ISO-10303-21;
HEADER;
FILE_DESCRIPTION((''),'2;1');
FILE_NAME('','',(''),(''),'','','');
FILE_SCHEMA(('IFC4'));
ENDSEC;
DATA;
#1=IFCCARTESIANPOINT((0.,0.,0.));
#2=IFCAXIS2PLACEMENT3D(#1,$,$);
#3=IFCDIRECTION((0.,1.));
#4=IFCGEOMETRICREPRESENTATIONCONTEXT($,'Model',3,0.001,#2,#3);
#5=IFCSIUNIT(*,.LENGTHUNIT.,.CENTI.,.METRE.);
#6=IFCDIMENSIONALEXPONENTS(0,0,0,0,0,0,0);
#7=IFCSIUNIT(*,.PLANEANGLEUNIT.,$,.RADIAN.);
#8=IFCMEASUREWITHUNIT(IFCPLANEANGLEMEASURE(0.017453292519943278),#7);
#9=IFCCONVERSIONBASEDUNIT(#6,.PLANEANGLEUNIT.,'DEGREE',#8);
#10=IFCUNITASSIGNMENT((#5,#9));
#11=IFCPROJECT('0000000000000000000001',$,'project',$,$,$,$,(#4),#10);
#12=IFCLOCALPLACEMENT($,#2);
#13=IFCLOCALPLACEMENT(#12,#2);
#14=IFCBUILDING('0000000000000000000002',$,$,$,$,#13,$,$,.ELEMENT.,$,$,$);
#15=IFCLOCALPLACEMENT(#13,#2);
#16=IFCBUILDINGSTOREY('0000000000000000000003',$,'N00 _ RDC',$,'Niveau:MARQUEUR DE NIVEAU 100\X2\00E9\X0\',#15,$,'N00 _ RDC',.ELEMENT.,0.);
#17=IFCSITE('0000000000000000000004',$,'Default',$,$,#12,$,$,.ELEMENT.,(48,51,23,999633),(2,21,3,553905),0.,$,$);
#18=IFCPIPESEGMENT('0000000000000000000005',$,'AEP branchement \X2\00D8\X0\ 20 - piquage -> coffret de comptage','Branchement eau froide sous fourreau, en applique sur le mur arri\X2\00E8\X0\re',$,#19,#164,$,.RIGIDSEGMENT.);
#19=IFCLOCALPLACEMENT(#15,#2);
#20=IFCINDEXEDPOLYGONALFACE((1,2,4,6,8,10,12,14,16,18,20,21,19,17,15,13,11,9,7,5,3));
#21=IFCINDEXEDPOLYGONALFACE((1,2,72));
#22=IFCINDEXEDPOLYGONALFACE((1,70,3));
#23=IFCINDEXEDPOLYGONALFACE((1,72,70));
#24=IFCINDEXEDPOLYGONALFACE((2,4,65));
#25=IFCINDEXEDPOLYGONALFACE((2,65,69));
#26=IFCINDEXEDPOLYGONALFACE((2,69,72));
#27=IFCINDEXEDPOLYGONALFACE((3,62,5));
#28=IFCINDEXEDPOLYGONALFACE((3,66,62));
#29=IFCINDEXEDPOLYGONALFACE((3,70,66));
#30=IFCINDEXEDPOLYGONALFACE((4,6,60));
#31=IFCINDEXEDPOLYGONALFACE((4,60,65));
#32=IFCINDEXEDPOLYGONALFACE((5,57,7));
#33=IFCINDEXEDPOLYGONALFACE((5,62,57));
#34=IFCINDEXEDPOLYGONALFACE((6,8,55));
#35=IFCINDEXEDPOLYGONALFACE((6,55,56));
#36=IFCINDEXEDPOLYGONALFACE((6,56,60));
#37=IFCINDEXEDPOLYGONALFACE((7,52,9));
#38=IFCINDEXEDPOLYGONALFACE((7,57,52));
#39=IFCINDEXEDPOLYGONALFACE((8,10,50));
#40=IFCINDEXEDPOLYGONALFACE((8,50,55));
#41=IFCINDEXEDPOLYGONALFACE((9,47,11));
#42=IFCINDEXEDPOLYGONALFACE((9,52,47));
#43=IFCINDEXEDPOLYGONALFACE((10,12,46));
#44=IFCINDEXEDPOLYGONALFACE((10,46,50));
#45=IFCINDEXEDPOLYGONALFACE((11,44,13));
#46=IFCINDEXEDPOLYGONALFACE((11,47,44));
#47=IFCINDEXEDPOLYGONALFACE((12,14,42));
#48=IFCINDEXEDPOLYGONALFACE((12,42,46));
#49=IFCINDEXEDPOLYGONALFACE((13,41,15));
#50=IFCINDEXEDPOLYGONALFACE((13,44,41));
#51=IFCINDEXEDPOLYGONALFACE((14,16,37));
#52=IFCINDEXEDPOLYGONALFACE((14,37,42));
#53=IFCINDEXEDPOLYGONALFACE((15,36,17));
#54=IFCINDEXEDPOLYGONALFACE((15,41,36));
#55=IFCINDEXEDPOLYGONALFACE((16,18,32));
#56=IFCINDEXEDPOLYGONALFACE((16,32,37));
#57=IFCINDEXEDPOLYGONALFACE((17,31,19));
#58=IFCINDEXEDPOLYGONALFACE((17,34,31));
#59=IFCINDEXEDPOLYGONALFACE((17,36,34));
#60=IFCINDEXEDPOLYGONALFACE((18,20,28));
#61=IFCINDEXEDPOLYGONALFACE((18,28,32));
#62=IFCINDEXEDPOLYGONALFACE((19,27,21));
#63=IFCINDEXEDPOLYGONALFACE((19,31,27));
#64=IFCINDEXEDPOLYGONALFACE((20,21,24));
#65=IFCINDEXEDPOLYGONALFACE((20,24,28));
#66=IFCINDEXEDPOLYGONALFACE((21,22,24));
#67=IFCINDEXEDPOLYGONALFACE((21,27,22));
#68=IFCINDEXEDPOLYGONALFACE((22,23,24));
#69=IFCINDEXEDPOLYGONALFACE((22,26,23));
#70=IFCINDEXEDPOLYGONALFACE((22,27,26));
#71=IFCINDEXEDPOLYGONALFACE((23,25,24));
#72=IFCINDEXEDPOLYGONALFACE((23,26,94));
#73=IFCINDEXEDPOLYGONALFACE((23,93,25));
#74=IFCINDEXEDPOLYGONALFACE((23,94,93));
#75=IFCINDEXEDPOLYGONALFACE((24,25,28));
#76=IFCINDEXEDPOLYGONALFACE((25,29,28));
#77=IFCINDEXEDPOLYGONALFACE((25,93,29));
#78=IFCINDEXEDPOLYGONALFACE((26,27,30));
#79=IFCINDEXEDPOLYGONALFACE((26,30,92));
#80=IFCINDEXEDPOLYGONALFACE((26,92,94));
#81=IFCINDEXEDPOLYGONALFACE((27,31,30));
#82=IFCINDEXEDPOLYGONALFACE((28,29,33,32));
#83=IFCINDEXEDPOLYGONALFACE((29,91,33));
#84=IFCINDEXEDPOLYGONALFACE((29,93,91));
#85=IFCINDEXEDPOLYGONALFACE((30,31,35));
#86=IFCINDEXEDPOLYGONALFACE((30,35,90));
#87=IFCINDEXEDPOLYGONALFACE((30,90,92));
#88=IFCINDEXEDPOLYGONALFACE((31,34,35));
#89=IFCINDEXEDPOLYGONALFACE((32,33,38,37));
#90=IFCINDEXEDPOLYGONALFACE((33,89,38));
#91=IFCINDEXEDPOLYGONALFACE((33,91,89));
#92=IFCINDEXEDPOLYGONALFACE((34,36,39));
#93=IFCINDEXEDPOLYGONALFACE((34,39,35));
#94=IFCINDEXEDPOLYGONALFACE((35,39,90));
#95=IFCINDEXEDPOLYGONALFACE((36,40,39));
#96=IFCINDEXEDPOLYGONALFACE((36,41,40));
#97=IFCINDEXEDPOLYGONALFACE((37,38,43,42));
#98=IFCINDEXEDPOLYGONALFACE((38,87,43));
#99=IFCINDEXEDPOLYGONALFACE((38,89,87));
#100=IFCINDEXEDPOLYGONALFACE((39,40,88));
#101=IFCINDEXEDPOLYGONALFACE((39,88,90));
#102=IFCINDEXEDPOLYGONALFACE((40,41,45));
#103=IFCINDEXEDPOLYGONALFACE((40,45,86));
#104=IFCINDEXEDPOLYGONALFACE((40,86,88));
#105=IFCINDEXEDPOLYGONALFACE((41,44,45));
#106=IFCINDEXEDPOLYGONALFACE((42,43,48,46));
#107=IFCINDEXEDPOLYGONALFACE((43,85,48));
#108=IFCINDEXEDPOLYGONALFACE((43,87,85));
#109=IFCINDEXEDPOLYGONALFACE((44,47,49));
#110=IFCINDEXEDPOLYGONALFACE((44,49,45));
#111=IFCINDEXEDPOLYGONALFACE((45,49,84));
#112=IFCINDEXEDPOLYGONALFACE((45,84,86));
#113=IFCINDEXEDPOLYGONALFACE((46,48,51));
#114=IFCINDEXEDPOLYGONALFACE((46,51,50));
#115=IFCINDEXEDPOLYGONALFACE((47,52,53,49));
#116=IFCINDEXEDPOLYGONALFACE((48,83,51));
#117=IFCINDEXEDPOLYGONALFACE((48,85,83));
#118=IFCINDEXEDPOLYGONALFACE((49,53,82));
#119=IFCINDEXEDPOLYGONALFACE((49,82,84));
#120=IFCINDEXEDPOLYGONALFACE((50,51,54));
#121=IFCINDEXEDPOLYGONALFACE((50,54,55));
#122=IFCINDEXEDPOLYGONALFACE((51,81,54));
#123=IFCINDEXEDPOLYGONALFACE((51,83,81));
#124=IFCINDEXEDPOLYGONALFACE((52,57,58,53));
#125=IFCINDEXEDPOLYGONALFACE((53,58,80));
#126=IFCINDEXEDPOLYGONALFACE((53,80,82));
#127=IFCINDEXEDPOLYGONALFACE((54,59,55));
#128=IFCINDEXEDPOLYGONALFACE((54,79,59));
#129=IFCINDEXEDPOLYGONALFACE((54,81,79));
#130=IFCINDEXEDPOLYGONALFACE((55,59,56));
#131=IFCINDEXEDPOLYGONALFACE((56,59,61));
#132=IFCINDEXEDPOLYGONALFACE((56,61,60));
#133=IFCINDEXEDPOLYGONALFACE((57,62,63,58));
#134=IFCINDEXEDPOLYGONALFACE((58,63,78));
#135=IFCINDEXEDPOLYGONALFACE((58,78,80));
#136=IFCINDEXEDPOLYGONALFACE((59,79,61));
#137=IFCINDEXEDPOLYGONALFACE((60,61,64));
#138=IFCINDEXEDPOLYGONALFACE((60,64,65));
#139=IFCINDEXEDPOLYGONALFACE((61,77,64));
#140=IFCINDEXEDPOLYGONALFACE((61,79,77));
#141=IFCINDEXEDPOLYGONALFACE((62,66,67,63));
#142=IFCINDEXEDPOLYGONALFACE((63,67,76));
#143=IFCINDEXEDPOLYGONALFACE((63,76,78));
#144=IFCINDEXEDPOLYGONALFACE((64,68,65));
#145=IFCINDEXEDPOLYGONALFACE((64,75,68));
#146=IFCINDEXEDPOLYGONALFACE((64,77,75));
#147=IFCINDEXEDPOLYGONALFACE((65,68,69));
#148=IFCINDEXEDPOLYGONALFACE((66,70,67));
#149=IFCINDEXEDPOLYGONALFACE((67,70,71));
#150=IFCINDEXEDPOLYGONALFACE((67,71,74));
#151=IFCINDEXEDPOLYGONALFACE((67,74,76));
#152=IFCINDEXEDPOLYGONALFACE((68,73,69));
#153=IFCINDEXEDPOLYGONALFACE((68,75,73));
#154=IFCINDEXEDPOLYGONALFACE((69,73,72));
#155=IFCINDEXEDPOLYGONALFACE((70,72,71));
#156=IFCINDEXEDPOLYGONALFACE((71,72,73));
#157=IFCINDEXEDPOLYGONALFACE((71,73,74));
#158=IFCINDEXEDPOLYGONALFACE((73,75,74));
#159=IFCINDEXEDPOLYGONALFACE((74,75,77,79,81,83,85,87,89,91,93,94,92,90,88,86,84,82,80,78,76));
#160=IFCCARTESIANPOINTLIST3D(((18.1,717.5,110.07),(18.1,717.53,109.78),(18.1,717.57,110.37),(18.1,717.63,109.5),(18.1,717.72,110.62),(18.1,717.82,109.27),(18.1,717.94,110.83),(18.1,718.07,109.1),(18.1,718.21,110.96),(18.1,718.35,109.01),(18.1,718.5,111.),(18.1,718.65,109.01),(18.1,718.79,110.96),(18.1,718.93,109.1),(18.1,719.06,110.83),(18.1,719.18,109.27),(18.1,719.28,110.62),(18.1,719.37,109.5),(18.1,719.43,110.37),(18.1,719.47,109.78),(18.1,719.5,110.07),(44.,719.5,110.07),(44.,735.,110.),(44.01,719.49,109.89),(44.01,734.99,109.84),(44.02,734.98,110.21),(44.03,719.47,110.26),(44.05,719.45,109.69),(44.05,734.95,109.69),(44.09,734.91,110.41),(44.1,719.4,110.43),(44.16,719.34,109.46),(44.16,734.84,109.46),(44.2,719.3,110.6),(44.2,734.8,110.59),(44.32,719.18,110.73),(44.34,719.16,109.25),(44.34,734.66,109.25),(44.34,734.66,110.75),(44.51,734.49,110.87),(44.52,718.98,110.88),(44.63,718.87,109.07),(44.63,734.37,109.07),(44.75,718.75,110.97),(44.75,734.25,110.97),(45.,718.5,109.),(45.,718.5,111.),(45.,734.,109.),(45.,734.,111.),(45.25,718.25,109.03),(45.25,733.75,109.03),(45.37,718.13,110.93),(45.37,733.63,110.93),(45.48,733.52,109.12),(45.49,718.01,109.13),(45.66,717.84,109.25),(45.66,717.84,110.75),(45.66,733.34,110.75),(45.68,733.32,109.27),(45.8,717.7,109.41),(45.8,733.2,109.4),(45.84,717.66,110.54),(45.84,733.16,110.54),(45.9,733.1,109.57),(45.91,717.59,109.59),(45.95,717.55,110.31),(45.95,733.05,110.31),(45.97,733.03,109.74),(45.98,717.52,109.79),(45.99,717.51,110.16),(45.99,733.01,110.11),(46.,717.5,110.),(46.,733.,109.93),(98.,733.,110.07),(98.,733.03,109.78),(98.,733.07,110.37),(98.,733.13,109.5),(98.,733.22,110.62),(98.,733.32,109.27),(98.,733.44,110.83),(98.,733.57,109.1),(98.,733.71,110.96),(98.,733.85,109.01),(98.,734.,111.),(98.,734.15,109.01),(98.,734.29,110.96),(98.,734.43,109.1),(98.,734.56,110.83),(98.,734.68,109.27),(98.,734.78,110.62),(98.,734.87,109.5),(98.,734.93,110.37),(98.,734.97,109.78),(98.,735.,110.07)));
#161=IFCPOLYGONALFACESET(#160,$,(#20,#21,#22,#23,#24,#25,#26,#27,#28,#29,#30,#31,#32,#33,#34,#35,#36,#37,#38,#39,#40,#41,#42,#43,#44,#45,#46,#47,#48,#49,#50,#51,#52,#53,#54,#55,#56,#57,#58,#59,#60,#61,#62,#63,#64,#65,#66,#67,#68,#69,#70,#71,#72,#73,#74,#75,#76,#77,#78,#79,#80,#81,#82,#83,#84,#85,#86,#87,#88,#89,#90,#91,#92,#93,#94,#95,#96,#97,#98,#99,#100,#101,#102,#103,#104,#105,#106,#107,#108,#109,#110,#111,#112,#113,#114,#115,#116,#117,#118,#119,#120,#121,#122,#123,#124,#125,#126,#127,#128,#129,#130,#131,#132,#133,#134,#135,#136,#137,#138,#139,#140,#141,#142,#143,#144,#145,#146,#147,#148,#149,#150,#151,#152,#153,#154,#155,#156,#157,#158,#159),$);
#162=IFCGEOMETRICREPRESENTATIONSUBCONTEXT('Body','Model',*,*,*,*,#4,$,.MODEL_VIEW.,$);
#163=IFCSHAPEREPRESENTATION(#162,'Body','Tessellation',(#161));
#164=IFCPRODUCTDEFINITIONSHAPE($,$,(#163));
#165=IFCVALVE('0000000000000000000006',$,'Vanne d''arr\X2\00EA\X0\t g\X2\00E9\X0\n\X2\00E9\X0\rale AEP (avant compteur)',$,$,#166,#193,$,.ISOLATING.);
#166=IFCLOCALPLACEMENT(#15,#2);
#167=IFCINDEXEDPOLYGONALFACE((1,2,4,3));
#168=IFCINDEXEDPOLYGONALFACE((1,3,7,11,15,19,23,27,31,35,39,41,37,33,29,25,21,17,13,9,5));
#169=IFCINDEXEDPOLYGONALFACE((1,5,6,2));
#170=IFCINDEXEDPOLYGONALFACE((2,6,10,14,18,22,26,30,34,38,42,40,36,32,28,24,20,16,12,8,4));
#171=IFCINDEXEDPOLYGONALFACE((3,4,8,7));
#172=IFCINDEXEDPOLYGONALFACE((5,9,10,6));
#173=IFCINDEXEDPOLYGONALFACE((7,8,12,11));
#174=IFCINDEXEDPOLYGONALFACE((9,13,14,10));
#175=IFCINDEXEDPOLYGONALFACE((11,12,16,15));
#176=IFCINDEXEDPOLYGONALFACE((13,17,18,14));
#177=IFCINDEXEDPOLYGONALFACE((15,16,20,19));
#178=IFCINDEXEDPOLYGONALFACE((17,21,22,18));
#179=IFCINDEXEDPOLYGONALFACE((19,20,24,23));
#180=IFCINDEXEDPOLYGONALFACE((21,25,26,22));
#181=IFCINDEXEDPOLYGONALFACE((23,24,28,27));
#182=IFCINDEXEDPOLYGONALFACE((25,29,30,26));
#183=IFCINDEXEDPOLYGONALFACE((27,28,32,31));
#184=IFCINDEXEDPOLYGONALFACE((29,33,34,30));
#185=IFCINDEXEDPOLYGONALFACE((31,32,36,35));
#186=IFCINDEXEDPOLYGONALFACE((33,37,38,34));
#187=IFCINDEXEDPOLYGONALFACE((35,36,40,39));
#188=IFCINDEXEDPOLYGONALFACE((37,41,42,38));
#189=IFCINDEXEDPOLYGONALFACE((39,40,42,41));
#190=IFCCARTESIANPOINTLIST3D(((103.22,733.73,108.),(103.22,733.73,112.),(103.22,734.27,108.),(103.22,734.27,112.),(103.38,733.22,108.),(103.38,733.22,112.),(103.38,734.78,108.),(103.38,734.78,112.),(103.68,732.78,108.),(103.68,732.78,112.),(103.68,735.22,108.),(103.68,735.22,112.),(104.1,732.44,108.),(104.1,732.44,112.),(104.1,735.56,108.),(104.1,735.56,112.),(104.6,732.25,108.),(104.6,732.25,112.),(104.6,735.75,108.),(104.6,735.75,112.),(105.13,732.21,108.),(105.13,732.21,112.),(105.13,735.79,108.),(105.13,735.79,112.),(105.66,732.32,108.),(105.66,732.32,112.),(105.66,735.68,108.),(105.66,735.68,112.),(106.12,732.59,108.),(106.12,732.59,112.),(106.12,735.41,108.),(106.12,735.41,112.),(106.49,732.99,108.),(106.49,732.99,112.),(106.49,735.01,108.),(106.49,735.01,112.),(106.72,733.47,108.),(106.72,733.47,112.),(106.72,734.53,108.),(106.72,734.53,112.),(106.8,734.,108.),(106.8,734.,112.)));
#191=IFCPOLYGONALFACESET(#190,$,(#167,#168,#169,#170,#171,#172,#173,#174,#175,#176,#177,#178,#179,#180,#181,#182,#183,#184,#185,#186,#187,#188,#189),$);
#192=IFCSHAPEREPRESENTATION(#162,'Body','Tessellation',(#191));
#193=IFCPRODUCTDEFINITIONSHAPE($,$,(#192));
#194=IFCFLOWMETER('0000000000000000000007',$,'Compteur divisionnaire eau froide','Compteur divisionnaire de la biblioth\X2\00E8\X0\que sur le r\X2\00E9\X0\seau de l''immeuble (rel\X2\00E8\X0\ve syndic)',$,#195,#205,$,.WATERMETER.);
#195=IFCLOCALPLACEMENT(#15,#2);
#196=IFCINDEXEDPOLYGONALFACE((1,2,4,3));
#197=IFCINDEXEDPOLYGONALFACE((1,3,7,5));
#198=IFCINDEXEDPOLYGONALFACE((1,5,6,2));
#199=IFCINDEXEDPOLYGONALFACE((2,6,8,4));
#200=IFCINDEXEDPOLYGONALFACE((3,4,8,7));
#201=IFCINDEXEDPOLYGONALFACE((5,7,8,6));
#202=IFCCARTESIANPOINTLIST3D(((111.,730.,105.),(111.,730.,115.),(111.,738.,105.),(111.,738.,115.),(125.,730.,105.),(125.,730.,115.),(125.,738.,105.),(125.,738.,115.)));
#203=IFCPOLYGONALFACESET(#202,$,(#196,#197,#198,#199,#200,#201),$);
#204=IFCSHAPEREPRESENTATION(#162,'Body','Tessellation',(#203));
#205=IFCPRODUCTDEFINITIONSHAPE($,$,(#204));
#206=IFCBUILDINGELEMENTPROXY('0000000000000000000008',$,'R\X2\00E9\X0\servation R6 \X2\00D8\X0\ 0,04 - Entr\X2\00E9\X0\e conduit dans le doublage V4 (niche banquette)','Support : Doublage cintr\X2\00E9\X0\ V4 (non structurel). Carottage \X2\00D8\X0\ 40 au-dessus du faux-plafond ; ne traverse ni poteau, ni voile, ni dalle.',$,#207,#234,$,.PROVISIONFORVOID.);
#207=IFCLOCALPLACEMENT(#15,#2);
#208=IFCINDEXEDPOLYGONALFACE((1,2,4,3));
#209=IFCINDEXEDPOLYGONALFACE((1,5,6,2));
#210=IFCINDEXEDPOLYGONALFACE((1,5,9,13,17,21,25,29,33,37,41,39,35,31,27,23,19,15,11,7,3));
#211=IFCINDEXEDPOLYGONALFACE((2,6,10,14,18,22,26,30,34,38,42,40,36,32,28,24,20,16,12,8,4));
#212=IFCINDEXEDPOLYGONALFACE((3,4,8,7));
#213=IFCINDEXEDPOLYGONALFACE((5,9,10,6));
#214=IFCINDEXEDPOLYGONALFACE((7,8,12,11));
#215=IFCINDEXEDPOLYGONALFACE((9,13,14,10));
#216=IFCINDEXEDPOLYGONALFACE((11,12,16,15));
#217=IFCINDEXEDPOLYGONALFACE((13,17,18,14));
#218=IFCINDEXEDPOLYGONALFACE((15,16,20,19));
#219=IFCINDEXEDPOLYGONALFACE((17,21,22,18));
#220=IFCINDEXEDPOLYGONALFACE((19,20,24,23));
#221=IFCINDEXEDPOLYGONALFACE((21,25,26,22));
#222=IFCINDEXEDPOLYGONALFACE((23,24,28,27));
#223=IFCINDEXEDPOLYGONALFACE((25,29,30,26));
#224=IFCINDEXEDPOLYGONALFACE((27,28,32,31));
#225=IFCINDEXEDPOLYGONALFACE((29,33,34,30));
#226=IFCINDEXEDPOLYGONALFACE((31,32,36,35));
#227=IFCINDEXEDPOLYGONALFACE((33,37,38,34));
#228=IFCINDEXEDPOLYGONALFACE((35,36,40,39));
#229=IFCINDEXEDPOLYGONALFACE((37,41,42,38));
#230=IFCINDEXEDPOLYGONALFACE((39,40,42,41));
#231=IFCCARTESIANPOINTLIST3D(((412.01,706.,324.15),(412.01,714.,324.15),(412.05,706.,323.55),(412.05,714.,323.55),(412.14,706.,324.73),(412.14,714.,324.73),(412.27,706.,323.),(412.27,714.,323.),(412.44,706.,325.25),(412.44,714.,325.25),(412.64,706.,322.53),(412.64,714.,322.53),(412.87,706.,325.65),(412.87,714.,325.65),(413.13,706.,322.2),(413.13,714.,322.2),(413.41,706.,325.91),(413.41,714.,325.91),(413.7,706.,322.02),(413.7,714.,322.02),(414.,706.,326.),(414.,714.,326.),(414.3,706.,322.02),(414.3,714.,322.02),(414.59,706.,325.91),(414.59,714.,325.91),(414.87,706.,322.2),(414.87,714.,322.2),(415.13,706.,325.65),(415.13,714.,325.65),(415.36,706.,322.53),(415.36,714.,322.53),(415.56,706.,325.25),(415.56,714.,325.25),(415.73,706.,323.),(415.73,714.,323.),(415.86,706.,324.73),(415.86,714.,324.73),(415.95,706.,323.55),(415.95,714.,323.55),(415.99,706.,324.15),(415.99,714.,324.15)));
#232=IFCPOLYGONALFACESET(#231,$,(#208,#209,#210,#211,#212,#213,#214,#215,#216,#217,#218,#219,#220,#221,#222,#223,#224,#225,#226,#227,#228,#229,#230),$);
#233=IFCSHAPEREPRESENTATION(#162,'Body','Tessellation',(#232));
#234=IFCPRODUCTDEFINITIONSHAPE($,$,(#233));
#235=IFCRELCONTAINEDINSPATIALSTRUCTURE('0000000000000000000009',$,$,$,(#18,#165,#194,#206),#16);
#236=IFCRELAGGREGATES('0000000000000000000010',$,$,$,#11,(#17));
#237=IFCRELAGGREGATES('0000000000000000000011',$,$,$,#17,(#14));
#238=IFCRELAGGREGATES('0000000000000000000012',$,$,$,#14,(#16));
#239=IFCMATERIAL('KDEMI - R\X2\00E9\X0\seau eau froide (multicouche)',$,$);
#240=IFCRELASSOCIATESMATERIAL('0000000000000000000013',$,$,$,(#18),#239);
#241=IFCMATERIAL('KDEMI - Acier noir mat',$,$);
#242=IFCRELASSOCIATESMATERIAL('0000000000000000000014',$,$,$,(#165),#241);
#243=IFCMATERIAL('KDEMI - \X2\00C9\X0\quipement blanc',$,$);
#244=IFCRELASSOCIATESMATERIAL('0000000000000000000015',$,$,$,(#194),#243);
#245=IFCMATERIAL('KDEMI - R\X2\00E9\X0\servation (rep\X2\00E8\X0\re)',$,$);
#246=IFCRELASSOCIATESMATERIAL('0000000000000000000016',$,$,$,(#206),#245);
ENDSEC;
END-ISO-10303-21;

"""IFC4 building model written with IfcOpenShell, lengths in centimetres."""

from ifc_helpers import new_model, entity, si_unit, converted_unit, direction, frame, frame_2d, origin, origin_with_axes, place, context, subcontext, project, spatial, rectangle, circle, extrude, material, element, save


model = new_model("IFC4")

# Units and contexts
model_context = context("Model", 3, precision=0.001, world=origin(), true_north=direction((0.0, 1.0)))
body_context = subcontext(model_context, "Body", "Model", "MODEL_VIEW")
ifc_project = project(units=[si_unit("LENGTHUNIT", "METRE", prefix="CENTI"), converted_unit("PLANEANGLEUNIT", "DEGREE", entity("IfcPlaneAngleMeasure", 0.017453292519943278), si_unit("PLANEANGLEUNIT", "RADIAN"), dimensions=[0, 0, 0, 0, 0, 0, 0])], contexts=[model_context])

# Site, building, storey
site_placement = place(None, origin())
site = spatial("IfcSite", under=ifc_project, at=site_placement, Name="Default", CompositionType="ELEMENT", RefLatitude=(48, 51, 23, 999633), RefLongitude=(2, 21, 3, 553905), RefElevation=0.0)
building_placement = place(site_placement, origin())
building = spatial("IfcBuilding", under=site, at=building_placement, CompositionType="ELEMENT")
storey_placement = place(building_placement, origin())
storey = spatial("IfcBuildingStorey", under=building, at=storey_placement, Name="N00 _ RDC", ObjectType="Niveau:MARQUEUR DE NIVEAU 100é", LongName="N00 _ RDC", CompositionType="ELEMENT", Elevation=0.0)

# Shared definitions
ifc_material_1 = material(Name="KDEMI - Réseau eau froide (multicouche)")

# Shared definitions
ifc_material_2 = material(Name="KDEMI - Acier noir mat")

# Pipe segment
pipe_segment_1_placement = place(storey_placement, origin_with_axes())
element("IfcPipeSegment", 1, at=pipe_segment_1_placement, inside=storey, material=ifc_material_1, Name="AEP branchement Ø 20 - piquage -> coffret de comptage", Description="Branchement eau froide sous fourreau, en applique sur le mur arrière", PredefinedType="RIGIDSEGMENT", context=body_context, shape_type="AdvancedSweptSolid", body=[
    entity("IfcSweptDiskSolid", entity("IfcPolyline", [entity("IfcCartesianPoint", [18.1, 718.5, 110.0]), entity("IfcCartesianPoint", [45.0, 718.5, 110.0]), entity("IfcCartesianPoint", [45.0, 734.0, 110.0]), entity("IfcCartesianPoint", [98.0, 734.0, 110.0])]), 1.0),
])

# Valve
valve_1_placement = place(storey_placement, origin_with_axes())
element("IfcValve", 2, at=valve_1_placement, inside=storey, material=ifc_material_2, Name="Vanne d'arrêt générale AEP (avant compteur)", PredefinedType="ISOLATING", context=body_context, shape_type="SweptSolid", body=[
    extrude(circle(Radius=1.8, at=frame_2d((105.0, 734.0))), frame((0.0, 0.0, 108.0)), (0.0, 0.0, 1.0), 4.0),
])

# Flow meter
ifc_material_3 = material(Name="KDEMI - Équipement blanc")
flow_meter_placement = place(storey_placement, origin_with_axes())
element("IfcFlowMeter", 3, at=flow_meter_placement, inside=storey, material=ifc_material_3, Name="Compteur divisionnaire eau froide", Description="Compteur divisionnaire de la bibliothèque sur le réseau de l'immeuble (relève syndic)", PredefinedType="WATERMETER", context=body_context, shape_type="SweptSolid", body=[
    extrude(rectangle(XDim=14.0, YDim=8.0, at=frame_2d((118.0, 734.0))), frame((0.0, 0.0, 105.0)), (0.0, 0.0, 1.0), 10.0),
])

# Building element proxy
ifc_material_4 = material(Name="KDEMI - Réservation (repère)")
proxy_1_placement = place(storey_placement, origin_with_axes())
element("IfcBuildingElementProxy", 4, at=proxy_1_placement, inside=storey, material=ifc_material_4, Name="Réservation R6 Ø 0,04 - Entrée conduit dans le doublage V4 (niche banquette)", Description="Support : Doublage cintré V4 (non structurel). Carottage Ø 40 au-dessus du faux-plafond ; ne traverse ni poteau, ni voile, ni dalle.", PredefinedType="PROVISIONFORVOID", context=body_context, shape_type="AdvancedSweptSolid", body=[
    entity("IfcSweptDiskSolid", entity("IfcPolyline", [entity("IfcCartesianPoint", [414.0, 706.0, 324.0]), entity("IfcCartesianPoint", [414.0, 714.0, 324.0])]), 2.0),
])

save(model, "model.ifc")
